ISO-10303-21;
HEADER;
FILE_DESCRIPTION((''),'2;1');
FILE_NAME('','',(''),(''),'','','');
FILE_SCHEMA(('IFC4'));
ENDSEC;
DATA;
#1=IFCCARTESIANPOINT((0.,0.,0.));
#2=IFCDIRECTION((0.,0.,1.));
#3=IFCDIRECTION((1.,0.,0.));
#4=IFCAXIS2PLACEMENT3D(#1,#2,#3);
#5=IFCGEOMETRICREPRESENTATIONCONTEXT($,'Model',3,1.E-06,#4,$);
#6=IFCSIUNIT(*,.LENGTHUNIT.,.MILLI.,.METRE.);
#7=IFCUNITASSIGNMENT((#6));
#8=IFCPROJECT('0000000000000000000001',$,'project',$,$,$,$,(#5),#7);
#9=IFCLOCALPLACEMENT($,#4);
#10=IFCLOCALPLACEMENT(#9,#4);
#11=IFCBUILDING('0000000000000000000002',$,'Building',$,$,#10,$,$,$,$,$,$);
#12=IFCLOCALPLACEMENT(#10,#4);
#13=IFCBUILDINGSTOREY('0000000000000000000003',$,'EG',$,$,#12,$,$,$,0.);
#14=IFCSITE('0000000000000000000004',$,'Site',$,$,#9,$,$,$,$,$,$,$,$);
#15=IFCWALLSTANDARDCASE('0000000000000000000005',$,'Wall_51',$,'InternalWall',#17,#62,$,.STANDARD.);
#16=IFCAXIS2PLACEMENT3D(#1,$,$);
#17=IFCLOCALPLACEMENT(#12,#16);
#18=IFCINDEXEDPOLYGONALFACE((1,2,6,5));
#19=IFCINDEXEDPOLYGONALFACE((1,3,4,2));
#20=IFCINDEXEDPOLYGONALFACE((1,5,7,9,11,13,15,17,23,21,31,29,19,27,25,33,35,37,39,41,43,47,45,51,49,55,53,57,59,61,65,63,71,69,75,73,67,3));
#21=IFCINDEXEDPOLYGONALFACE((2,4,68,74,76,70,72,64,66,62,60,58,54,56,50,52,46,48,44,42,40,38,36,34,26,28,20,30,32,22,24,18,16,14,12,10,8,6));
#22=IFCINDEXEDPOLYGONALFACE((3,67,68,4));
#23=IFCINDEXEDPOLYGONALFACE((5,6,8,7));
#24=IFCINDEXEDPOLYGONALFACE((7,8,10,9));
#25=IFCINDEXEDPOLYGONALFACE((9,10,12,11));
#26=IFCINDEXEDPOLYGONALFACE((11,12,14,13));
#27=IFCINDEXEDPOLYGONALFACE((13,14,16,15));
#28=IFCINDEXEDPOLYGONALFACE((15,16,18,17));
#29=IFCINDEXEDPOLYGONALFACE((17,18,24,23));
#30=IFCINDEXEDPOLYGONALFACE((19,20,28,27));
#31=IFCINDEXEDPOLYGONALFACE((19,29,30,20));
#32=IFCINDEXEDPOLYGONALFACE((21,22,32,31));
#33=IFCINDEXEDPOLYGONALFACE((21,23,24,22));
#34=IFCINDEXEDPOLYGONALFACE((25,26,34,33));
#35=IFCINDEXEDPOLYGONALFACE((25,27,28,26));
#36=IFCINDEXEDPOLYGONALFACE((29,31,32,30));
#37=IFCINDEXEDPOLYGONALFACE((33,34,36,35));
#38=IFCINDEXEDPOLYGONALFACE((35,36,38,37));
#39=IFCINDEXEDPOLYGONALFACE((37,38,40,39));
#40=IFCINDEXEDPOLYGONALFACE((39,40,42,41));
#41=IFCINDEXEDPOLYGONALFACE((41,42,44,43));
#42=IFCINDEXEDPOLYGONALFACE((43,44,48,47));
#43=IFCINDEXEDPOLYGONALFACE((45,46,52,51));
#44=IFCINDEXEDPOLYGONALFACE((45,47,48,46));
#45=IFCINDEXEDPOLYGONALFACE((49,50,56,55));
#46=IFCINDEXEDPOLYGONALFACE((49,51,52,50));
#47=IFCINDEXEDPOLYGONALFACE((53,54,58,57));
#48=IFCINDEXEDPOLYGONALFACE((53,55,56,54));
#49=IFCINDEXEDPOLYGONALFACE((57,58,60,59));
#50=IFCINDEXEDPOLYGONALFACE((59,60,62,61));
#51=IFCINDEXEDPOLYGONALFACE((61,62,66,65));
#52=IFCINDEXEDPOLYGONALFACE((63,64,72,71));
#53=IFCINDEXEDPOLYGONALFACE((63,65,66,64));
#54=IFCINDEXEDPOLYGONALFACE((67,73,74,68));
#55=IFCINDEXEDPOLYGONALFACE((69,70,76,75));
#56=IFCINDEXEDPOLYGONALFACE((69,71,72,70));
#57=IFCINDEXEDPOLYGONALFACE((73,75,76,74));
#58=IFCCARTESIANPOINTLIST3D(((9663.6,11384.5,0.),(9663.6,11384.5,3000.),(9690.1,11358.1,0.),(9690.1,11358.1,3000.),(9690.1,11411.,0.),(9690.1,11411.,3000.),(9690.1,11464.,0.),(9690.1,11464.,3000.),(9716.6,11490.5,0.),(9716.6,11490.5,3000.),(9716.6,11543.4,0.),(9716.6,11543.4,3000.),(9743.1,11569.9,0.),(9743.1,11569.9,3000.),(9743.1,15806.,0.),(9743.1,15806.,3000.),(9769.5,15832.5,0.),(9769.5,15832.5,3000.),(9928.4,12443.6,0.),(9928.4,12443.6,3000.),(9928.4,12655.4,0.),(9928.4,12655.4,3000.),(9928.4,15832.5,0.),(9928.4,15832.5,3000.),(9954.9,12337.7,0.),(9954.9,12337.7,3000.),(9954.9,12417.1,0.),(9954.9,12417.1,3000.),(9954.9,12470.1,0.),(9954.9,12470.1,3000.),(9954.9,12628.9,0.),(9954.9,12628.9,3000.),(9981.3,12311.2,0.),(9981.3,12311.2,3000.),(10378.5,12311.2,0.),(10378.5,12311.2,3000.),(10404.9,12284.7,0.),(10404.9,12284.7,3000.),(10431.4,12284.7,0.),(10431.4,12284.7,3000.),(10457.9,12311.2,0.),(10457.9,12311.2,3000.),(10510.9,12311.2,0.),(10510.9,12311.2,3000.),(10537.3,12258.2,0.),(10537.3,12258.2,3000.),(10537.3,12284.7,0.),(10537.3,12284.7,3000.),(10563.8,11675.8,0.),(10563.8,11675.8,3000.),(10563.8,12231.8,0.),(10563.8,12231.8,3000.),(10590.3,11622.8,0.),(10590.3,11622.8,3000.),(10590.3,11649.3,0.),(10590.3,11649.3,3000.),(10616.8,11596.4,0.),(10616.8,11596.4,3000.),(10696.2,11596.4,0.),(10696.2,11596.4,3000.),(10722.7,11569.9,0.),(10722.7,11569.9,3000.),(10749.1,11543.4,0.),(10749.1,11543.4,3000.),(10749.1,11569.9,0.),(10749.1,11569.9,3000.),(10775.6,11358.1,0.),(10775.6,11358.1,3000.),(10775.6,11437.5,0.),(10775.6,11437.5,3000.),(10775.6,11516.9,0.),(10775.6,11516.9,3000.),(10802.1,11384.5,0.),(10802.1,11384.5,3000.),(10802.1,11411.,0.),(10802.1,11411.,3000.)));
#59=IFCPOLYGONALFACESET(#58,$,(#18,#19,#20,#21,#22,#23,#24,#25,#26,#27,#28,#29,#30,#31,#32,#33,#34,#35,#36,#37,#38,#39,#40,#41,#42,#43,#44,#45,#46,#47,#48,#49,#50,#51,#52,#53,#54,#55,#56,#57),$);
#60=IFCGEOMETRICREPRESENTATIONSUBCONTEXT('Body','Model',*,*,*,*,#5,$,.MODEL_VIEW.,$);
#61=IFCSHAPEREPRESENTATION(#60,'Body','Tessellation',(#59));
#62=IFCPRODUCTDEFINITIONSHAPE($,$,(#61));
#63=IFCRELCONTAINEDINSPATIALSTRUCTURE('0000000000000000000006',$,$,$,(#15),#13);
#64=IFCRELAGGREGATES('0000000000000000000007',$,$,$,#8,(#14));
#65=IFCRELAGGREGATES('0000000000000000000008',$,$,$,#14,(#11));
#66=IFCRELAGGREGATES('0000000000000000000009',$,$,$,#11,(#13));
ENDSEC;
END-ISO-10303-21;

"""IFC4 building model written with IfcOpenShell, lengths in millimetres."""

from ifc_helpers import new_model, si_unit, frame, origin_with_axes, place, context, subcontext, project, spatial, polyline, outline, extrude, element, save


model = new_model("IFC4")

# Units and contexts
model_context = context("Model", 3, precision=1e-06, world=origin_with_axes())
body_context = subcontext(model_context, "Body", "Model", "MODEL_VIEW")
ifc_project = project(units=[si_unit("LENGTHUNIT", "METRE", prefix="MILLI")], contexts=[model_context])

# Site, building, storey
site_placement = place(None, origin_with_axes())
site = spatial("IfcSite", under=ifc_project, at=site_placement, Name="Site")
building_placement = place(site_placement, origin_with_axes())
building = spatial("IfcBuilding", under=site, at=building_placement, Name="Building")
storey_placement = place(building_placement, origin_with_axes())
storey = spatial("IfcBuildingStorey", under=building, at=storey_placement, Name="EG", Elevation=0.0)

# Wall
for number, where, z_axis, x_axis, name in (
    (1, (0.0, 0.0, 0.0), (0.0, 0.0, 1.0), (1.0, 0.0, 0.0), "Wall_51"),
):
    element("IfcWallStandardCase", number, at=place(storey_placement, frame(where, z_axis=z_axis, x_axis=x_axis)), inside=storey, Name=name, ObjectType="InternalWall", PredefinedType="STANDARD", context=body_context, shape_type="SweptSolid", body=[
        extrude(outline(polyline([(9690.1, 11358.1, 0.0), (9663.6, 11384.5, 0.0), (9690.1, 11411.0, 0.0), (9690.1, 11464.0, 0.0), (9716.6, 11490.5, 0.0), (9716.6, 11543.4, 0.0), (9743.1, 11569.9, 0.0), (9743.1, 15806.0, 0.0), (9769.5, 15832.5, 0.0), (9928.4, 15832.5, 0.0), (9928.4, 12655.4, 0.0), (9954.9, 12628.9, 0.0), (9954.9, 12470.1, 0.0), (9928.4, 12443.6, 0.0), (9954.9, 12417.1, 0.0), (9954.9, 12337.7, 0.0), (9981.3, 12311.2, 0.0), (10378.5, 12311.2, 0.0), (10404.9, 12284.7, 0.0), (10431.4, 12284.7, 0.0), (10457.9, 12311.2, 0.0), (10510.9, 12311.2, 0.0), (10537.3, 12284.7, 0.0), (10537.3, 12258.2, 0.0), (10563.8, 12231.8, 0.0), (10563.8, 11675.8, 0.0), (10590.3, 11649.3, 0.0), (10590.3, 11622.8, 0.0), (10616.8, 11596.4, 0.0), (10696.2, 11596.4, 0.0), (10722.7, 11569.9, 0.0), (10749.1, 11569.9, 0.0), (10749.1, 11543.4, 0.0), (10775.6, 11516.9, 0.0), (10775.6, 11437.5, 0.0), (10802.1, 11411.0, 0.0), (10802.1, 11384.5, 0.0), (10775.6, 11358.1, 0.0), (9690.1, 11358.1, 0.0)])), origin_with_axes(), (0.0, 0.0, 1.0), 3000.0),
    ])

save(model, "model.ifc")
